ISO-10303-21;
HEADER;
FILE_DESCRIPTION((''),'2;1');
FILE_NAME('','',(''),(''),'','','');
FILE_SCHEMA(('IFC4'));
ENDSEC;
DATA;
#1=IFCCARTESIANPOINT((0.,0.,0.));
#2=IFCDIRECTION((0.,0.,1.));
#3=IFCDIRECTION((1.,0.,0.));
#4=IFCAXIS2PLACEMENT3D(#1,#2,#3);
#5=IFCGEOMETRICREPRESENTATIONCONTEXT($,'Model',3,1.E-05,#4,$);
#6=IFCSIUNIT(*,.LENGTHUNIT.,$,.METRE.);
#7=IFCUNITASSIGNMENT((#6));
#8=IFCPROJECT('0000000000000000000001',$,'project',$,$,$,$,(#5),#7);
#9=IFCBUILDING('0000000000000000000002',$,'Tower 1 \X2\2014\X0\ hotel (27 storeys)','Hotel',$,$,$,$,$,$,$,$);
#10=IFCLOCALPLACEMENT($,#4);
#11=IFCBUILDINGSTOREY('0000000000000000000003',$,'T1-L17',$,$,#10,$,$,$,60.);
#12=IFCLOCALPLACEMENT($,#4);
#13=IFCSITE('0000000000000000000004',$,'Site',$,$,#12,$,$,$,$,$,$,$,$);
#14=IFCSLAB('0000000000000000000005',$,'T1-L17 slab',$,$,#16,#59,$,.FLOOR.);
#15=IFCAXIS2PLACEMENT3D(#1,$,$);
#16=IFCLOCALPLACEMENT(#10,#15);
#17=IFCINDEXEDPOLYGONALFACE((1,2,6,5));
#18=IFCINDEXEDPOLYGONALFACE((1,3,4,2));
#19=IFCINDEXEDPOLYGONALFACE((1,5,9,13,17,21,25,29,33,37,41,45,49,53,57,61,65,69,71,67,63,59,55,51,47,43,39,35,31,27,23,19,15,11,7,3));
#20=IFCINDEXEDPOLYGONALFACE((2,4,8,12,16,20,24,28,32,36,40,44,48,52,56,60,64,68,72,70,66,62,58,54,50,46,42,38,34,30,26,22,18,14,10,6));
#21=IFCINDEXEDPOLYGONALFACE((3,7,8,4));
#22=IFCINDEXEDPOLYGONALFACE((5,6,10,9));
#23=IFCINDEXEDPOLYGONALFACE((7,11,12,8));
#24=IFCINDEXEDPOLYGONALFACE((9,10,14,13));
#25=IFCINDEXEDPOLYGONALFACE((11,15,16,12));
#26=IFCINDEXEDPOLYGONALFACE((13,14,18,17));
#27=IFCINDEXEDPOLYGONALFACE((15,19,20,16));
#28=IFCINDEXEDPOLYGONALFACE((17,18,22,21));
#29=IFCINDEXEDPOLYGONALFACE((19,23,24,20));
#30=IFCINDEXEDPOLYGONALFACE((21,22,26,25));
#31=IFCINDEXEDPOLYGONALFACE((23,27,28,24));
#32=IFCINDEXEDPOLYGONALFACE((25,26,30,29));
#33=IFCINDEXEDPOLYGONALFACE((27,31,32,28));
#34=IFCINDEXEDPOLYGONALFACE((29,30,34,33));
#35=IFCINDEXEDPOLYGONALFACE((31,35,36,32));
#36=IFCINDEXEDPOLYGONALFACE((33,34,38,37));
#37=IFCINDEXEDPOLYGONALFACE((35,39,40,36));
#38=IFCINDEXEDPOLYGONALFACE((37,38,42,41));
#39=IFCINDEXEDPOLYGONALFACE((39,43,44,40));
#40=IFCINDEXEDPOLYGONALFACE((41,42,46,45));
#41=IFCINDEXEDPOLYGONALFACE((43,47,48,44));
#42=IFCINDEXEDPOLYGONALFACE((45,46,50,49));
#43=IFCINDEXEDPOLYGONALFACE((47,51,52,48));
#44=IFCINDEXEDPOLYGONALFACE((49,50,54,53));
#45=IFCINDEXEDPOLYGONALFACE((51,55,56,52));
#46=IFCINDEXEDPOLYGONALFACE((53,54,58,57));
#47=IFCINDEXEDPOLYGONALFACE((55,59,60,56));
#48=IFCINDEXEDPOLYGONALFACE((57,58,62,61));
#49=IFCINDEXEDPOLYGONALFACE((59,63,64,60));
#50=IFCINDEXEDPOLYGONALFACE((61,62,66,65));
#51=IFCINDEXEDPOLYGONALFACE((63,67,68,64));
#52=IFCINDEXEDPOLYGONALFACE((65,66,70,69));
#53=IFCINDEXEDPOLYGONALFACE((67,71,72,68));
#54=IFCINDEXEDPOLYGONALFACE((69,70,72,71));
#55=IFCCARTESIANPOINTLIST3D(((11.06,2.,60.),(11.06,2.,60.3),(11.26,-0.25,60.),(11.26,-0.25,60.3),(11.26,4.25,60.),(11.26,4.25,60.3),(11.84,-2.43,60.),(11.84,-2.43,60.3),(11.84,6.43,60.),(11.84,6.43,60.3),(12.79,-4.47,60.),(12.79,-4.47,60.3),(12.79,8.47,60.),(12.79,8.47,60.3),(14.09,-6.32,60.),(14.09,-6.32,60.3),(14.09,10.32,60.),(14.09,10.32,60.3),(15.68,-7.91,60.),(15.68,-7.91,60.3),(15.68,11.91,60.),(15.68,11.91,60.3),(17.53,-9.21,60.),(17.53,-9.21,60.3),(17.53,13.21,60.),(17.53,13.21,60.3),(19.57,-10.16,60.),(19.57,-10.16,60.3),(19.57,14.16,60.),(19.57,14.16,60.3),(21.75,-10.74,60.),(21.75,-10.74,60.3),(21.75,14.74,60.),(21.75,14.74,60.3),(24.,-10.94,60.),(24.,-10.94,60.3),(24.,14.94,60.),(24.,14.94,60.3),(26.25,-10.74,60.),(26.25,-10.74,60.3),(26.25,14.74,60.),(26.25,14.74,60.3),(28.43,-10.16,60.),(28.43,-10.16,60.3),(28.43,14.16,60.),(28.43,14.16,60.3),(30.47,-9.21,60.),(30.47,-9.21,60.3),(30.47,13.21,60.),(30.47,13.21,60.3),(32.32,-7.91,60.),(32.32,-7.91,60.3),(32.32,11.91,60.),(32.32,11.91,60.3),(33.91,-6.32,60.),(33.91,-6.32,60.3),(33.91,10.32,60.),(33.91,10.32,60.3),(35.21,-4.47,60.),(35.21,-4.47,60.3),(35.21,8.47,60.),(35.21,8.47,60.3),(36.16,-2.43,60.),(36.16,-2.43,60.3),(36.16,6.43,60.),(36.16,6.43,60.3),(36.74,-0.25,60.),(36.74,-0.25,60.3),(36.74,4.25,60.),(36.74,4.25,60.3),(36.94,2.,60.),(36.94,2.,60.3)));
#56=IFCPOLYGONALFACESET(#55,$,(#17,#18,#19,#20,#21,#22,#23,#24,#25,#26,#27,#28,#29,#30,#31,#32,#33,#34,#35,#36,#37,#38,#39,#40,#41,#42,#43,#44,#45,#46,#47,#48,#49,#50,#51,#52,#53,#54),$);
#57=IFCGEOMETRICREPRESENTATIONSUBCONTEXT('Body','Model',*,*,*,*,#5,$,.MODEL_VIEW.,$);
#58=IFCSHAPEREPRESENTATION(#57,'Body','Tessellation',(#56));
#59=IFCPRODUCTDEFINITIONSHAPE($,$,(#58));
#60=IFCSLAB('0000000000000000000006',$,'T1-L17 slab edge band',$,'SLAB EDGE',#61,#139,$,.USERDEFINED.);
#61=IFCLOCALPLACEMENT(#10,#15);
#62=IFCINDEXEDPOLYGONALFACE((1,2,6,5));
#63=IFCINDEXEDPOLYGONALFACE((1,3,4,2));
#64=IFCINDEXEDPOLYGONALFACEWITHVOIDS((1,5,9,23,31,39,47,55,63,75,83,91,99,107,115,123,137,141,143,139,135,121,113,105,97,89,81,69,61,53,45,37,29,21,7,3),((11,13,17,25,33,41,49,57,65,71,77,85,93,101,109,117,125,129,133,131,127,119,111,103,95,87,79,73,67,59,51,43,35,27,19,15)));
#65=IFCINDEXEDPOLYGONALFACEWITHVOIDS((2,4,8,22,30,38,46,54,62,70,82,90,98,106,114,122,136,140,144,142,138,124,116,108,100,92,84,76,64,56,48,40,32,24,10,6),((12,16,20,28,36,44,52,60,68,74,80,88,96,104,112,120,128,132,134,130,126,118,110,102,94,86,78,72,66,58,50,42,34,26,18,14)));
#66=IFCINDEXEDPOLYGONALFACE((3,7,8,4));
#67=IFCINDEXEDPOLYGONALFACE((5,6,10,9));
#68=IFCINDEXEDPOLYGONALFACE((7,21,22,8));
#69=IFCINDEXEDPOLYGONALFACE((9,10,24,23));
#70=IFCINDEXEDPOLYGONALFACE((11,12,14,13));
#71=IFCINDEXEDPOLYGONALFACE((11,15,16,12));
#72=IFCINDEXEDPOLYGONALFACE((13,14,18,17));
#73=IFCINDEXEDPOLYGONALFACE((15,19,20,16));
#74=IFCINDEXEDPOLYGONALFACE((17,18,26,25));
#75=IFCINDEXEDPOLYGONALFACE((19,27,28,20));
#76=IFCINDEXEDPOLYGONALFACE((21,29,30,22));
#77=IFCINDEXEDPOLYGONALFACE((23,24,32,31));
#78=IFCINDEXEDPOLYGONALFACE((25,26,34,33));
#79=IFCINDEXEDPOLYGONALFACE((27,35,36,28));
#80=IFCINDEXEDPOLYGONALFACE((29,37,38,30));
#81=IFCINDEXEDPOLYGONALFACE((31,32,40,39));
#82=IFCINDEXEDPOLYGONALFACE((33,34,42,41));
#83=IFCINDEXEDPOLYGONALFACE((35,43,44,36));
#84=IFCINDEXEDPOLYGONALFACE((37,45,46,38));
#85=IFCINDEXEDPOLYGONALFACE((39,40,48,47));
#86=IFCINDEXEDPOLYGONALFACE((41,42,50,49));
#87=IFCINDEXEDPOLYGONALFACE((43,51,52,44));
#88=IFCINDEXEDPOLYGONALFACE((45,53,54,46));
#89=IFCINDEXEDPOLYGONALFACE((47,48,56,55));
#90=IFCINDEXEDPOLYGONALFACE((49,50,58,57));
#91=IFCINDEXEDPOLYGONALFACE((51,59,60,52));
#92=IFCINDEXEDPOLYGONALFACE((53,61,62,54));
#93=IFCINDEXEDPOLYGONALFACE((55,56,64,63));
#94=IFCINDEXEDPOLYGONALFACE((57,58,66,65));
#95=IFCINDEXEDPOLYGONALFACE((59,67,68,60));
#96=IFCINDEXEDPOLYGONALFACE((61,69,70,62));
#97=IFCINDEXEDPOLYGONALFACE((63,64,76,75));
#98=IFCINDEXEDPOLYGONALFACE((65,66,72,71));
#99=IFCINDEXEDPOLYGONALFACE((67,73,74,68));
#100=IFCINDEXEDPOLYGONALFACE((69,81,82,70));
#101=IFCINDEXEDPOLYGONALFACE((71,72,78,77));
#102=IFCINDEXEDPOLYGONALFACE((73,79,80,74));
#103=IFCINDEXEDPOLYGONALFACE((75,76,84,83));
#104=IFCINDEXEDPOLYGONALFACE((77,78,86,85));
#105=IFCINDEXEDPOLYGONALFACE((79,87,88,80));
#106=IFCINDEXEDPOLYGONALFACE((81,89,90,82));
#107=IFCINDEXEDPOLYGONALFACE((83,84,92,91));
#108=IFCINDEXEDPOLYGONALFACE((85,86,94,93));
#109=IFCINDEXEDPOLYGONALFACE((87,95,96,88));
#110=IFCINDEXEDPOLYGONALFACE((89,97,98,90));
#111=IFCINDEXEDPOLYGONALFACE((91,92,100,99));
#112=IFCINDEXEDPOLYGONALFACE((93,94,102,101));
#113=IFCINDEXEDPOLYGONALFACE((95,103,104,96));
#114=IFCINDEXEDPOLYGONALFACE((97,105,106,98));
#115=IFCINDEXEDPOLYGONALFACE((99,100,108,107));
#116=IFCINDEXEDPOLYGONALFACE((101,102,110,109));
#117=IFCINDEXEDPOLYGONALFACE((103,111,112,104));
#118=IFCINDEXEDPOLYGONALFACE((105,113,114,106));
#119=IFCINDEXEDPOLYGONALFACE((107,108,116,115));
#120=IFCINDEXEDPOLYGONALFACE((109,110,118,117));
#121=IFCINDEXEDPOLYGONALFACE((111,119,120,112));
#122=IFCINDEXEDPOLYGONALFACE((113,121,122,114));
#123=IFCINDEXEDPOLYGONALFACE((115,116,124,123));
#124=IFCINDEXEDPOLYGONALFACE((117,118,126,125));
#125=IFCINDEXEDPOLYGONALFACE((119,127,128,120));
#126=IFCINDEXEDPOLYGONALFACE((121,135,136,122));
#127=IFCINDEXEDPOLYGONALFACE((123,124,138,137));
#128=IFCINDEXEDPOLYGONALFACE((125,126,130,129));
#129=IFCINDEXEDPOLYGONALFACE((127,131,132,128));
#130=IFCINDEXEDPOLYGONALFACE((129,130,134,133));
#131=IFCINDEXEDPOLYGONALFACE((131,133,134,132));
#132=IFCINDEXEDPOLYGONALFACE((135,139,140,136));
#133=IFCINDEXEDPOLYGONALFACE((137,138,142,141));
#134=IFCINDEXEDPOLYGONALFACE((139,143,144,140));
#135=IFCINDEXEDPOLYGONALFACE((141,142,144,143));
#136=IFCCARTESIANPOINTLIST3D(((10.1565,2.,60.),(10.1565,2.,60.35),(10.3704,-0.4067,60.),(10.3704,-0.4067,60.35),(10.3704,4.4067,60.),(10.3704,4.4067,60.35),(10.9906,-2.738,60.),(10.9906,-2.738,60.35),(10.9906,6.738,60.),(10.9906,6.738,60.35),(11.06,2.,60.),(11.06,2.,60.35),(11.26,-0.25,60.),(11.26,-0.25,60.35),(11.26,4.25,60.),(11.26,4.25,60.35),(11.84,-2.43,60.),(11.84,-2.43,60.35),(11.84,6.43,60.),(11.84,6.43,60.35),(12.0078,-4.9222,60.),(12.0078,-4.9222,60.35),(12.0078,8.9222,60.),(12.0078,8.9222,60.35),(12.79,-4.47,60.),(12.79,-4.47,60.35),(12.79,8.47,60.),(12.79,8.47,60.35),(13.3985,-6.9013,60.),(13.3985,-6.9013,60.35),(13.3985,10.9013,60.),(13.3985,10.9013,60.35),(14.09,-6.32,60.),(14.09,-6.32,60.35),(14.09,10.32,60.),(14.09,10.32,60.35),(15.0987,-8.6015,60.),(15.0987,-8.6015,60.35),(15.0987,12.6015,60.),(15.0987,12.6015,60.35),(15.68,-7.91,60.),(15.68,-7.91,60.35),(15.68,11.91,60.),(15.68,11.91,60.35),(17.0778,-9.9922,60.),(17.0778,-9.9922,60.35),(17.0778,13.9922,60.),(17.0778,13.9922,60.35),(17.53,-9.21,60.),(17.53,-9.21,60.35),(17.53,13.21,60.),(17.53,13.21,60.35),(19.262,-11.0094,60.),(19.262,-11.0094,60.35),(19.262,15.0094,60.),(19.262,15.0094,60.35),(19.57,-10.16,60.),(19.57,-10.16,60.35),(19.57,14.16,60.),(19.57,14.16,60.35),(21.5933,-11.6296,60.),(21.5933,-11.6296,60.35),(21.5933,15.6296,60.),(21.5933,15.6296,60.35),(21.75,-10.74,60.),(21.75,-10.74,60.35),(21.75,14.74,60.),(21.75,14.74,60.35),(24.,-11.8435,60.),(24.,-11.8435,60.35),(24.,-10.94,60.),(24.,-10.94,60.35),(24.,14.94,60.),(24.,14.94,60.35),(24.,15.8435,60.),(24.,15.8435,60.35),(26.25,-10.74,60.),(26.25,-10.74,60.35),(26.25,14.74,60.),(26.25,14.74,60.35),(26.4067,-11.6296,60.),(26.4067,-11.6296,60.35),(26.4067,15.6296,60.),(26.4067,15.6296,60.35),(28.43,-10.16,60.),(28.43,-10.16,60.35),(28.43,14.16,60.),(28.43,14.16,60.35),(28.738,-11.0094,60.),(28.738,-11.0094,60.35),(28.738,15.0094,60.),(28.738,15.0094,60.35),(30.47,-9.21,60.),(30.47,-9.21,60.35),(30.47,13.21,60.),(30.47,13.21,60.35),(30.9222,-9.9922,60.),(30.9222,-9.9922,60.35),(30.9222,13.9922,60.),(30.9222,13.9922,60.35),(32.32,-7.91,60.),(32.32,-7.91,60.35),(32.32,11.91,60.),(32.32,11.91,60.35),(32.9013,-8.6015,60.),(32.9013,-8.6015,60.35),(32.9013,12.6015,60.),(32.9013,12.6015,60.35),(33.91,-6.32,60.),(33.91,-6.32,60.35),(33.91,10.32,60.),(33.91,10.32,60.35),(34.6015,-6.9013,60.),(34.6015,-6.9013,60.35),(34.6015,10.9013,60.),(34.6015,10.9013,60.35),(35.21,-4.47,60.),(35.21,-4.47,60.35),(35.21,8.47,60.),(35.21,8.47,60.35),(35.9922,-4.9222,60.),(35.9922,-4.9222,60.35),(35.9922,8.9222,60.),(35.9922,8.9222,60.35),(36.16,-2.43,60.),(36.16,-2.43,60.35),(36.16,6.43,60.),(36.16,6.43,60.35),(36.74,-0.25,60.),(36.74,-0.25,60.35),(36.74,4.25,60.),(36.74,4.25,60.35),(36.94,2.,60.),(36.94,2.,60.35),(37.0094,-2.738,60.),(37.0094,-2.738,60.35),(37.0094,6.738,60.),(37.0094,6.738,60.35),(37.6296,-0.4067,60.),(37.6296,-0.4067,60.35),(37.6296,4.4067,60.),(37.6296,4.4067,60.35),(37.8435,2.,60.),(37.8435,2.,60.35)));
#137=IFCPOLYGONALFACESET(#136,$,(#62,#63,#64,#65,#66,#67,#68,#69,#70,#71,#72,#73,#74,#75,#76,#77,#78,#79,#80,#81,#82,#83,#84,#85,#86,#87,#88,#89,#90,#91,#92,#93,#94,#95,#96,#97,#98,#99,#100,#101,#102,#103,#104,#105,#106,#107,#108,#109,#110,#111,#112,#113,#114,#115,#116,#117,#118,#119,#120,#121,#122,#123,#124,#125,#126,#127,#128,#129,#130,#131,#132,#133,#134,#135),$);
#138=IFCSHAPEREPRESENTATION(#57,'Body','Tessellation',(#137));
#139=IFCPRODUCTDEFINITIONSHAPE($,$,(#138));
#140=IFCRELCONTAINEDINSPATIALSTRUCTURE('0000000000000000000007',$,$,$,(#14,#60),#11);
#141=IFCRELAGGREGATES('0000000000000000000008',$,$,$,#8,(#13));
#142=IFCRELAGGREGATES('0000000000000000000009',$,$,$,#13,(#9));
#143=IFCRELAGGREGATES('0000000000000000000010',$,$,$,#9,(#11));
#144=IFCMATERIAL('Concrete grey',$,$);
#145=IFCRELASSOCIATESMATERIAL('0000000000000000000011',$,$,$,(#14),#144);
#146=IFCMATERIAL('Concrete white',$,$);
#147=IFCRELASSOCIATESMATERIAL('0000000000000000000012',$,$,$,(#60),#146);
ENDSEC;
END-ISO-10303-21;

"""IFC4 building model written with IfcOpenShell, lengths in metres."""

from ifc_helpers import new_model, si_unit, frame, origin_with_axes, place, context, subcontext, project, spatial, polyline, outline, extrude, material, element, save


model = new_model("IFC4")

# Units and contexts
model_context = context("Model", 3, precision=1e-05, world=origin_with_axes())
body_context = subcontext(model_context, "Body", "Model", "MODEL_VIEW")
ifc_project = project(units=[si_unit("LENGTHUNIT", "METRE")], contexts=[model_context])

# Site, building, storey
site_placement = place(None, origin_with_axes())
site = spatial("IfcSite", under=ifc_project, at=site_placement, Name="Site")
building = spatial("IfcBuilding", under=site, Name="Tower 1 — hotel (27 storeys)", Description="Hotel")
storey_placement = place(None, origin_with_axes())
storey = spatial("IfcBuildingStorey", under=building, at=storey_placement, Name="T1-L17", Elevation=60.0)

# Slab
ifc_material_1 = material(Name="Concrete grey")
slab_1_placement = place(storey_placement, origin_with_axes())
element("IfcSlab", 1, at=slab_1_placement, inside=storey, material=ifc_material_1, Name="T1-L17 slab", PredefinedType="FLOOR", context=body_context, shape_type="SweptSolid", body=[
    extrude(outline(polyline([(36.94, 2.0), (36.74, 4.25), (36.16, 6.43), (35.21, 8.47), (33.91, 10.32), (32.32, 11.91), (30.47, 13.21), (28.43, 14.16), (26.25, 14.74), (24.0, 14.94), (21.75, 14.74), (19.57, 14.16), (17.53, 13.21), (15.68, 11.91), (14.09, 10.32), (12.79, 8.47), (11.84, 6.43), (11.26, 4.25), (11.06, 2.0), (11.26, -0.25), (11.84, -2.43), (12.79, -4.47), (14.09, -6.32), (15.68, -7.91), (17.53, -9.21), (19.57, -10.16), (21.75, -10.74), (24.0, -10.94), (26.25, -10.74), (28.43, -10.16), (30.47, -9.21), (32.32, -7.91), (33.91, -6.32), (35.21, -4.47), (36.16, -2.43), (36.74, -0.25), (36.94, 2.0)])), frame((0.0, 0.0, 60.0), z_axis=(0.0, 0.0, 1.0), x_axis=(1.0, 0.0, 0.0)), (0.0, 0.0, 1.0), 0.3),
])

# Slab
ifc_material_2 = material(Name="Concrete white")
slab_2_placement = place(storey_placement, origin_with_axes())
element("IfcSlab", 2, at=slab_2_placement, inside=storey, material=ifc_material_2, Name="T1-L17 slab edge band", ObjectType="SLAB EDGE", PredefinedType="USERDEFINED", context=body_context, shape_type="SweptSolid", body=[
    extrude(outline(polyline([(37.8435, 2.0), (37.6296, 4.4067), (37.0094, 6.738), (35.9922, 8.9222), (34.6015, 10.9013), (32.9013, 12.6015), (30.9222, 13.9922), (28.738, 15.0094), (26.4067, 15.6296), (24.0, 15.8435), (21.5933, 15.6296), (19.262, 15.0094), (17.0778, 13.9922), (15.0987, 12.6015), (13.3985, 10.9013), (12.0078, 8.9222), (10.9906, 6.738), (10.3704, 4.4067), (10.1565, 2.0), (10.3704, -0.4067), (10.9906, -2.738), (12.0078, -4.9222), (13.3985, -6.9013), (15.0987, -8.6015), (17.0778, -9.9922), (19.262, -11.0094), (21.5933, -11.6296), (24.0, -11.8435), (26.4067, -11.6296), (28.738, -11.0094), (30.9222, -9.9922), (32.9013, -8.6015), (34.6015, -6.9013), (35.9922, -4.9222), (37.0094, -2.738), (37.6296, -0.4067), (37.8435, 2.0)]), holes=[polyline([(36.94, 2.0), (36.74, 4.25), (36.16, 6.43), (35.21, 8.47), (33.91, 10.32), (32.32, 11.91), (30.47, 13.21), (28.43, 14.16), (26.25, 14.74), (24.0, 14.94), (21.75, 14.74), (19.57, 14.16), (17.53, 13.21), (15.68, 11.91), (14.09, 10.32), (12.79, 8.47), (11.84, 6.43), (11.26, 4.25), (11.06, 2.0), (11.26, -0.25), (11.84, -2.43), (12.79, -4.47), (14.09, -6.32), (15.68, -7.91), (17.53, -9.21), (19.57, -10.16), (21.75, -10.74), (24.0, -10.94), (26.25, -10.74), (28.43, -10.16), (30.47, -9.21), (32.32, -7.91), (33.91, -6.32), (35.21, -4.47), (36.16, -2.43), (36.74, -0.25), (36.94, 2.0)])]), frame((0.0, 0.0, 60.0), z_axis=(0.0, 0.0, 1.0), x_axis=(1.0, 0.0, 0.0)), (0.0, 0.0, 1.0), 0.35),
])

save(model, "model.ifc")
